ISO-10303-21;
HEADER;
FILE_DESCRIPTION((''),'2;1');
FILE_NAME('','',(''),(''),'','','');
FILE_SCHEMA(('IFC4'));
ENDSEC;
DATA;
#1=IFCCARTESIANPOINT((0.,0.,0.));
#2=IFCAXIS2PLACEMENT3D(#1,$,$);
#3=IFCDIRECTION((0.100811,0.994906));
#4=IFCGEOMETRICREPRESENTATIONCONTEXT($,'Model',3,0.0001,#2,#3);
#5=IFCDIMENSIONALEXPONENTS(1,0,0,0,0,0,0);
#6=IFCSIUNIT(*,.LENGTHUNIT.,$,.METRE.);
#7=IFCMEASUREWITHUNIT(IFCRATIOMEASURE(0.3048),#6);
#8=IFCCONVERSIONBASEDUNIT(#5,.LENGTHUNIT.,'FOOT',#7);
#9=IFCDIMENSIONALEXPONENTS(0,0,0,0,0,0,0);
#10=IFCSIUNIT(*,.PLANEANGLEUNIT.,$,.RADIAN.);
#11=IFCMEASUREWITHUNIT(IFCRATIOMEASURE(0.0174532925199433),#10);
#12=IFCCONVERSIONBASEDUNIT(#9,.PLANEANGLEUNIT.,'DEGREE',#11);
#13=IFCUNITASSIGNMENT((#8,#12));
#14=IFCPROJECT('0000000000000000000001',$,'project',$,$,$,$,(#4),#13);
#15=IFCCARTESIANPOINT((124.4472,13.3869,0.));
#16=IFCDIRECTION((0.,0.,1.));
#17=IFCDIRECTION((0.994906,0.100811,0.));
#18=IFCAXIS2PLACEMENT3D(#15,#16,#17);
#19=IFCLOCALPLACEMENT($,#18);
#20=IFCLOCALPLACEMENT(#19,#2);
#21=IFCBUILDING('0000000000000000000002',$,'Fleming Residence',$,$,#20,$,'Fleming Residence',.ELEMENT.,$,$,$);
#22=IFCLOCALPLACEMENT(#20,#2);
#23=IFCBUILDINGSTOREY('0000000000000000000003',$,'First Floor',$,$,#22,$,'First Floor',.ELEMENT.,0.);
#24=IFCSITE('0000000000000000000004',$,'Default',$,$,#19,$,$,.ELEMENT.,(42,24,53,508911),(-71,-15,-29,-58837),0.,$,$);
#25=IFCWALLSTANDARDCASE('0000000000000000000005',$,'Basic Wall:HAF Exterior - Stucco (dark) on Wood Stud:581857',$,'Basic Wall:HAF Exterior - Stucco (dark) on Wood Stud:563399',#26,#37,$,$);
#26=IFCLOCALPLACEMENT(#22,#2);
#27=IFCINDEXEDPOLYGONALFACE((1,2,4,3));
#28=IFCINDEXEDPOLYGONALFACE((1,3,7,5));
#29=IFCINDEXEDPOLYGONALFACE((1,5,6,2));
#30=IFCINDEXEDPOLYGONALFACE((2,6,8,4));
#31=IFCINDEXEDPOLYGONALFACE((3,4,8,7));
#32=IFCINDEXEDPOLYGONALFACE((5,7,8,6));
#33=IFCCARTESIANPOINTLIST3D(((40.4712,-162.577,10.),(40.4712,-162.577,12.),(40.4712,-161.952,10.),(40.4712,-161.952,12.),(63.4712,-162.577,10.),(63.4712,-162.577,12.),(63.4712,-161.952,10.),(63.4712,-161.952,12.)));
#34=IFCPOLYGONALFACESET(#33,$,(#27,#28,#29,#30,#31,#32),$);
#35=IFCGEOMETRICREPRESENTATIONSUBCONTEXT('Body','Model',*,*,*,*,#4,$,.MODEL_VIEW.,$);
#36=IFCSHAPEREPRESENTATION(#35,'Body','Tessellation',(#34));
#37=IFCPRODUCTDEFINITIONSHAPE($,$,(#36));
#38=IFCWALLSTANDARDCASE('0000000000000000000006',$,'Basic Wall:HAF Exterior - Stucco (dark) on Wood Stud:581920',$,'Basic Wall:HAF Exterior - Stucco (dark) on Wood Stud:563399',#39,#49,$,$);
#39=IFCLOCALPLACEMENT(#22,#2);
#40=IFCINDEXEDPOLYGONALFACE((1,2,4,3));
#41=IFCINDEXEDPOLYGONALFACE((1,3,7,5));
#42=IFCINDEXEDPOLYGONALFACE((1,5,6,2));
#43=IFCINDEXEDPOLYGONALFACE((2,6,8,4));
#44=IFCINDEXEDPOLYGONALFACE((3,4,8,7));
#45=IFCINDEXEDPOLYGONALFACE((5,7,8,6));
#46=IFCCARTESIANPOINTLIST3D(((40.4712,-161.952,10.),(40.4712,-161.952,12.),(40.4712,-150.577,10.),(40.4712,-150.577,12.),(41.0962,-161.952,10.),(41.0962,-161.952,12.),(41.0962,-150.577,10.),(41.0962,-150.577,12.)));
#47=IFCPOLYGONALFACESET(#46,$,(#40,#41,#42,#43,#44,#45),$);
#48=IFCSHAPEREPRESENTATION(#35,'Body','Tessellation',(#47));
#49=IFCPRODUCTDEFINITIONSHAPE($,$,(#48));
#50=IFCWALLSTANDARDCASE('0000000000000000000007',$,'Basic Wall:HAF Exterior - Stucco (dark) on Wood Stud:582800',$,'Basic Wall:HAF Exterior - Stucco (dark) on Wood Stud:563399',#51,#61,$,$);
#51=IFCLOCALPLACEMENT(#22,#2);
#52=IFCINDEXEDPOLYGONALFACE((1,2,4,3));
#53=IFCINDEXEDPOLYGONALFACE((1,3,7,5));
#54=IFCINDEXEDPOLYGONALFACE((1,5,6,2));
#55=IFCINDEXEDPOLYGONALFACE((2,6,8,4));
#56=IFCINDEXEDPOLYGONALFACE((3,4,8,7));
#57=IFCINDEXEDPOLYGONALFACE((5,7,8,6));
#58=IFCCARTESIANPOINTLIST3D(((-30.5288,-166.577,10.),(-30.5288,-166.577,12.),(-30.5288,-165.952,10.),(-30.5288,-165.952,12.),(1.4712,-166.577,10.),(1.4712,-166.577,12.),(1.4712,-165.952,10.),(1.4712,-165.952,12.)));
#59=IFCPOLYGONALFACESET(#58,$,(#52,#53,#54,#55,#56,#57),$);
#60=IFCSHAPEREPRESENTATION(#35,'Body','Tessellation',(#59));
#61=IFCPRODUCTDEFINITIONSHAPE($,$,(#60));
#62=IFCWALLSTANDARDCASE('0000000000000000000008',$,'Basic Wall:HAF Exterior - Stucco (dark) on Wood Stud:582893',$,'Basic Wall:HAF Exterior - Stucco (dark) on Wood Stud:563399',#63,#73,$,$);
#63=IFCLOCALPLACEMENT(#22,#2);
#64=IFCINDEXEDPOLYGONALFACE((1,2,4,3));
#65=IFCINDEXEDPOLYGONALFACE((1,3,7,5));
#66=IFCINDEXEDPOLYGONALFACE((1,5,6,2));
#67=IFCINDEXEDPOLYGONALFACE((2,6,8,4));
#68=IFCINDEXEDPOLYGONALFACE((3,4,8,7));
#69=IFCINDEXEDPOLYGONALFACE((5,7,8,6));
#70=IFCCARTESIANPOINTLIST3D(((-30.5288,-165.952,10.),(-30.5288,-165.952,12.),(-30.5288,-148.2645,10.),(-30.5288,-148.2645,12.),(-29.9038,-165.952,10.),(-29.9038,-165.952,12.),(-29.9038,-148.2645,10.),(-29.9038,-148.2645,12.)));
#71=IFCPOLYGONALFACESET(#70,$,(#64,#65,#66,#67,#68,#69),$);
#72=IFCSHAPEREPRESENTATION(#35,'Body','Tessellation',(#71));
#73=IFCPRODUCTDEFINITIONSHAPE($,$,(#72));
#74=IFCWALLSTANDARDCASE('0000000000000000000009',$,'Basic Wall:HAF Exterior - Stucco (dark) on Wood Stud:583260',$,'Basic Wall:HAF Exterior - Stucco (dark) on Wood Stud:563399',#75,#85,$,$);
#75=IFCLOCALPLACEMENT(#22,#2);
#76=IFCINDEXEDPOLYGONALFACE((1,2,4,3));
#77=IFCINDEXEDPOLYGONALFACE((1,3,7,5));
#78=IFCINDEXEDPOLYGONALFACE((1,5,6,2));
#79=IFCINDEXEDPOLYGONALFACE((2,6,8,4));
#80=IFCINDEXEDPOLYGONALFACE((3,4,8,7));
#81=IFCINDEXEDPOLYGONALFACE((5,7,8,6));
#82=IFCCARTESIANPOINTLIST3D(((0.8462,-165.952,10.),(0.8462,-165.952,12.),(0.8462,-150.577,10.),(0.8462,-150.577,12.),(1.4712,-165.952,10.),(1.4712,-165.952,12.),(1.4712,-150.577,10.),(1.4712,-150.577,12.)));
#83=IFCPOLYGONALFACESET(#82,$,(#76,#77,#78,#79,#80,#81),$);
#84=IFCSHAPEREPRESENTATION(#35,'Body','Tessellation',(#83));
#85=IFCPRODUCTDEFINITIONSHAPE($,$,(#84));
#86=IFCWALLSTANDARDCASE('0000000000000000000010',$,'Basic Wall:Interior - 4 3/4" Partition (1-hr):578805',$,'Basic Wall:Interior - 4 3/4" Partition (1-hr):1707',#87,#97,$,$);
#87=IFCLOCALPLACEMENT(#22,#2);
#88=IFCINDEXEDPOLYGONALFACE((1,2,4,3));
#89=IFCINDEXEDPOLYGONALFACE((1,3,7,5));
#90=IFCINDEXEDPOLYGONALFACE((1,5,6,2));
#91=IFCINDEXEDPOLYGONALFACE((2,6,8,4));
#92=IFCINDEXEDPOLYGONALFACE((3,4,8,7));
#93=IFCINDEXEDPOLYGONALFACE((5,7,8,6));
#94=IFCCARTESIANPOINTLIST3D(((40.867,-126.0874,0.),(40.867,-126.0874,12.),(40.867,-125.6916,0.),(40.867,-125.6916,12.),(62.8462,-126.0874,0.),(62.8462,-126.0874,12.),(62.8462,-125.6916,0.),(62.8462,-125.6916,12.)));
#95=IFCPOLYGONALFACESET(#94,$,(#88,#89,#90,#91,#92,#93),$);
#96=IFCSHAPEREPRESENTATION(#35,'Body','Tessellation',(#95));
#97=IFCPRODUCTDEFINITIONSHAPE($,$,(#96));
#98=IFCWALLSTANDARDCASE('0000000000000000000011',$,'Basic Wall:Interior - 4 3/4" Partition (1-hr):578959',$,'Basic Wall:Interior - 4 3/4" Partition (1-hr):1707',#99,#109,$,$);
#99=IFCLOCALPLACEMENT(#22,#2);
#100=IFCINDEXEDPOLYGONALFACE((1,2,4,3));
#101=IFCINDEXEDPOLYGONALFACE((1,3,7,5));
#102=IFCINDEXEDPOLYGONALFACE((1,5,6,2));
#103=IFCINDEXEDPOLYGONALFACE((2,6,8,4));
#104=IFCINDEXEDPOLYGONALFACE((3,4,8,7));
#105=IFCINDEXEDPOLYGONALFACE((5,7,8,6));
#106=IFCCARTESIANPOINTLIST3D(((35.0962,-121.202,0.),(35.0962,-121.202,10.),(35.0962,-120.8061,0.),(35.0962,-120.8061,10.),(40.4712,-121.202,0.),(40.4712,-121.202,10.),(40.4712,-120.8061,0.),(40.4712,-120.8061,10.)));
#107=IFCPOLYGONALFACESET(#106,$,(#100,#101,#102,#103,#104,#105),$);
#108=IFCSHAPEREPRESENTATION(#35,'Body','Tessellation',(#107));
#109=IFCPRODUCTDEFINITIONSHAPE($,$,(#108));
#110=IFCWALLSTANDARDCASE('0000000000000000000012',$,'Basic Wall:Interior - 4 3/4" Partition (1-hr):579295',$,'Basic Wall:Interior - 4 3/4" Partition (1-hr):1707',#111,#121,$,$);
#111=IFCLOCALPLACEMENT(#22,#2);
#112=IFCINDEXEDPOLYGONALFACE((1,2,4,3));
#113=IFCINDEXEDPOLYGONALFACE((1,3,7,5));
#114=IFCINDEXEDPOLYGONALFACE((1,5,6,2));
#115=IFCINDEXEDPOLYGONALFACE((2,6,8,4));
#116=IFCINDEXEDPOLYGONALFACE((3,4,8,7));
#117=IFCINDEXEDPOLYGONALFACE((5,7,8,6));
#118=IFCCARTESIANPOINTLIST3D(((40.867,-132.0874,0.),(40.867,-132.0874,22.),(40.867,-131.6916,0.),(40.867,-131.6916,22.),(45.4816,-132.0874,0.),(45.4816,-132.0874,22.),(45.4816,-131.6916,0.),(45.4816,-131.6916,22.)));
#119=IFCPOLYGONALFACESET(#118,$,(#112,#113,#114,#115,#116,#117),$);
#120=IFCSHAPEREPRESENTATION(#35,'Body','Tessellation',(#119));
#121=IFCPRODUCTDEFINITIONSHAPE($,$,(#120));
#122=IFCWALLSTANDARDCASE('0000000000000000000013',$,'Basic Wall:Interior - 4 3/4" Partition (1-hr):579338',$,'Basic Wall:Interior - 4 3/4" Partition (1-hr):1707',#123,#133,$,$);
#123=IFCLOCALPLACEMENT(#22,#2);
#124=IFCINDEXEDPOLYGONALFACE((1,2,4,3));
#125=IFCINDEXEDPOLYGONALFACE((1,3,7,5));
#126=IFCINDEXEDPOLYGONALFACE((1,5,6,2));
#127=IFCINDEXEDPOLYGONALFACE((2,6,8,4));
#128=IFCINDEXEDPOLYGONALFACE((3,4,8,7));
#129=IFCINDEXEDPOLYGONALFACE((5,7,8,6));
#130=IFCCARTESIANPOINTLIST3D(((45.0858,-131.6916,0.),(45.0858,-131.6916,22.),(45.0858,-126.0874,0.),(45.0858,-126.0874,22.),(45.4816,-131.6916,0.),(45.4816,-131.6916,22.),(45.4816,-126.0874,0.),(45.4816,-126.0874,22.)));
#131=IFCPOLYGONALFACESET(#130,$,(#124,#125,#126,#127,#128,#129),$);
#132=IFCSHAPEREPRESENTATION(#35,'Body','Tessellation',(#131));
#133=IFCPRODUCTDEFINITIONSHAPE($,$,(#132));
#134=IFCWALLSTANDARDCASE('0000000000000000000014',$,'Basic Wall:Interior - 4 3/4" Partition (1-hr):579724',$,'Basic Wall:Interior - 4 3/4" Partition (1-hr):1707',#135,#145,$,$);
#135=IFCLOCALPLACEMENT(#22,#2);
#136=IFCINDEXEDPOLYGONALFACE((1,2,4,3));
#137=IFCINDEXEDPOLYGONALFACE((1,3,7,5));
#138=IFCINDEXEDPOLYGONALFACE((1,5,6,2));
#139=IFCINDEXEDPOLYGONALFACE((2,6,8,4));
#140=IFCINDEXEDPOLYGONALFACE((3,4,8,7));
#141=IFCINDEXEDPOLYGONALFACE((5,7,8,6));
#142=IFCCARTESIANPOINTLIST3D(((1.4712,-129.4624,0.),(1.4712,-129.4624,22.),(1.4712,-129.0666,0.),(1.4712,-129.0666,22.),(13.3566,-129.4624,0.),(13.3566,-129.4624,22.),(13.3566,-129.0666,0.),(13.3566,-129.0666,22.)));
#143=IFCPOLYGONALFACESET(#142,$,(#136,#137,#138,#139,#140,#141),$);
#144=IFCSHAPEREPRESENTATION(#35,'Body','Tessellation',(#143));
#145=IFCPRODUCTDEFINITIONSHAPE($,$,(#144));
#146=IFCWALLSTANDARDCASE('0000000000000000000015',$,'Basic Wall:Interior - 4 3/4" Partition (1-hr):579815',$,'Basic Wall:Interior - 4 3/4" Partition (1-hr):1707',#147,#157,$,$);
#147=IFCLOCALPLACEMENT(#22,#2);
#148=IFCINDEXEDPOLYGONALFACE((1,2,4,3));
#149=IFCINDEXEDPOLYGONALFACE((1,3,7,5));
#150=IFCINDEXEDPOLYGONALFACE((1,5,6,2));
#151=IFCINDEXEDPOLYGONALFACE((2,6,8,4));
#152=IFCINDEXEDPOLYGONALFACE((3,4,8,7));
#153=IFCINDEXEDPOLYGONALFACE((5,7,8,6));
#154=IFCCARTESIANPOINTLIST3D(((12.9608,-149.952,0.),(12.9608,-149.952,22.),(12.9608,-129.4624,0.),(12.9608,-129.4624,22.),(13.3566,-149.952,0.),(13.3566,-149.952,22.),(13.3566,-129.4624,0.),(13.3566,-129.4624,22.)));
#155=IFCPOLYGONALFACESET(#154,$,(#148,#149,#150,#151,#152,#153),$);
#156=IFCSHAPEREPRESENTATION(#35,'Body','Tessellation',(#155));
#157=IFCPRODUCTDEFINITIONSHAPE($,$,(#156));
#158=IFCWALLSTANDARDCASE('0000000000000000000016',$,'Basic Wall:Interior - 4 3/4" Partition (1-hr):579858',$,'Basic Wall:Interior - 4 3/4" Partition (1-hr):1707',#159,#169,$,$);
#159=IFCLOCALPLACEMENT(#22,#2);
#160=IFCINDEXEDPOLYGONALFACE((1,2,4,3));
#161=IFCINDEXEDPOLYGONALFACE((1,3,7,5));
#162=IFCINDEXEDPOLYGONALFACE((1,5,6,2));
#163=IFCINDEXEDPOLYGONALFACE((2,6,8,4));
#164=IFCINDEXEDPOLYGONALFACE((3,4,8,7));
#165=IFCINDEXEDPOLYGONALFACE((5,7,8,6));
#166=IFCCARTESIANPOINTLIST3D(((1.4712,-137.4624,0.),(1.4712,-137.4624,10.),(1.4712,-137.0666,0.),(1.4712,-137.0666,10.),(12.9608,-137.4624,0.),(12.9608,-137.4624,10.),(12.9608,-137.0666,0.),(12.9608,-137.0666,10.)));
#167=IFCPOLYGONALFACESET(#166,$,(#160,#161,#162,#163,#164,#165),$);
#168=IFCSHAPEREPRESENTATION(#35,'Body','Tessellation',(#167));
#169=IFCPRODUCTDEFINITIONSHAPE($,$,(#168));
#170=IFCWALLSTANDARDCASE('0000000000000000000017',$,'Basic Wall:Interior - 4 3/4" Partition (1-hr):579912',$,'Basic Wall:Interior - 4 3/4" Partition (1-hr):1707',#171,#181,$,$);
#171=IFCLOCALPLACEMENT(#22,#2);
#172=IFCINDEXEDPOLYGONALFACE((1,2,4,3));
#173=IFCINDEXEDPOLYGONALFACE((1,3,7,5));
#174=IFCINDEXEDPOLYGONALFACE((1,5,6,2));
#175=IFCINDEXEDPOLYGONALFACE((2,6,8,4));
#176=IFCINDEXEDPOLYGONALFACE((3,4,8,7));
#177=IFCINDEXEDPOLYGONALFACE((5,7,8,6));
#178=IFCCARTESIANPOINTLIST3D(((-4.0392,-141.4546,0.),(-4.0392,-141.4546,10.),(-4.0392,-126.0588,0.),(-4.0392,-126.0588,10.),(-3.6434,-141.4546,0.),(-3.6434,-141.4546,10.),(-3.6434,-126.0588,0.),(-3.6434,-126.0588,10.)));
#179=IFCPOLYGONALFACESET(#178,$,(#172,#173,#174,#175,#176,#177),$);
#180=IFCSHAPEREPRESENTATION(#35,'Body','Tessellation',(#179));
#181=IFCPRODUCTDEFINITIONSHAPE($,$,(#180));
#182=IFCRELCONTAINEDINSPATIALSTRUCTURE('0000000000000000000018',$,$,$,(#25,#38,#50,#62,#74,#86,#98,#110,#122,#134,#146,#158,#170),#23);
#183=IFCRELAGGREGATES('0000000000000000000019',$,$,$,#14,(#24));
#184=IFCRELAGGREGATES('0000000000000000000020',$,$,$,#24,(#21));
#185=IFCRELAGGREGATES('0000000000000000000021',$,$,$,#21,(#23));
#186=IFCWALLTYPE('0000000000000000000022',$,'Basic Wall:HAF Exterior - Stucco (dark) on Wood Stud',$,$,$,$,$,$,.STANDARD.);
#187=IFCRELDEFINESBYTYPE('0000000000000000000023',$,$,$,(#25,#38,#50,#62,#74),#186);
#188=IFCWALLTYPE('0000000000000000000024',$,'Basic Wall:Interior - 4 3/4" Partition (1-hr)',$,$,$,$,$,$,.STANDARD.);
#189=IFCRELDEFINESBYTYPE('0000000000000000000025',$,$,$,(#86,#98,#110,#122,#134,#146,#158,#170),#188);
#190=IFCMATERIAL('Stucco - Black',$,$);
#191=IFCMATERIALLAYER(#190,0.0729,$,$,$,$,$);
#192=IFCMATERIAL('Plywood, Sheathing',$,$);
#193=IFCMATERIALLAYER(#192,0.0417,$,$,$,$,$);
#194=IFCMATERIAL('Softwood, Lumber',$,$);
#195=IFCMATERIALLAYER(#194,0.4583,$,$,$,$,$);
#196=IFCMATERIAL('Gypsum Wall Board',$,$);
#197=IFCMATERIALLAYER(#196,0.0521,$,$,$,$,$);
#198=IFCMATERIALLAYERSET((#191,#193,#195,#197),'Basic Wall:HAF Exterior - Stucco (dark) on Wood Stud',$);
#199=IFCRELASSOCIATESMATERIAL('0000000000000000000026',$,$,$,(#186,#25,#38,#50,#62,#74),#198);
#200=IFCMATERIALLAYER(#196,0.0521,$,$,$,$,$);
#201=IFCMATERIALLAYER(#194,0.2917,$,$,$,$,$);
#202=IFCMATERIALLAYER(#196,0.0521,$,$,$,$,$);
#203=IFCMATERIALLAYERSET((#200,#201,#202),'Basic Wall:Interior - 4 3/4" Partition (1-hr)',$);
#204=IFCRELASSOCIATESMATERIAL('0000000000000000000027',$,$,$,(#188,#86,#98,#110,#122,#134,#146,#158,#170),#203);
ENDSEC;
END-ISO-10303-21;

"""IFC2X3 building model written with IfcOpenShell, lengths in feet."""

from ifc_helpers import new_model, entity, si_unit, converted_unit, direction, frame, frame_2d, origin, place, context, subcontext, project, spatial, rectangle, extrude, material, layer, layer_set, layer_usage, type_object, element, save


model = new_model("IFC2X3")

# Units and contexts
model_context = context("Model", 3, precision=0.0001, world=origin(), true_north=direction((0.100811, 0.994906)))
body_context = subcontext(model_context, "Body", "Model", "MODEL_VIEW")
ifc_project = project(units=[converted_unit("LENGTHUNIT", "FOOT", entity("IfcRatioMeasure", 0.3048), si_unit("LENGTHUNIT", "METRE"), dimensions=[1, 0, 0, 0, 0, 0, 0]), converted_unit("PLANEANGLEUNIT", "DEGREE", entity("IfcRatioMeasure", 0.0174532925199433), si_unit("PLANEANGLEUNIT", "RADIAN"), dimensions=[0, 0, 0, 0, 0, 0, 0])], contexts=[model_context])

# Site, building, storey
site_placement = place(None, frame((124.4472, 13.3869, 0.0), z_axis=(0.0, 0.0, 1.0), x_axis=(0.994906, 0.100811, 0.0)))
site = spatial("IfcSite", under=ifc_project, at=site_placement, Name="Default", CompositionType="ELEMENT", RefLatitude=(42, 24, 53, 508911), RefLongitude=(-71, -15, -29, -58837), RefElevation=0.0)
building_placement = place(site_placement, origin())
building = spatial("IfcBuilding", under=site, at=building_placement, Name="Fleming Residence", LongName="Fleming Residence", CompositionType="ELEMENT")
storey_placement = place(building_placement, origin())
storey = spatial("IfcBuildingStorey", under=building, at=storey_placement, Name="First Floor", LongName="First Floor", CompositionType="ELEMENT", Elevation=0.0)

# Walls
ifc_material_1 = material(Name="Plywood, Sheathing")
ifc_material_2 = material(Name="Softwood, Lumber")
ifc_material_3 = material(Name="Gypsum Wall Board")
ifc_material_4 = material(Name="Stucco - Black")
ifc_layer_1 = layer(ifc_material_4, 0.0729)
ifc_layer_2 = layer(ifc_material_1, 0.0417)
ifc_layer_3 = layer(ifc_material_2, 0.4583)
ifc_layer_4 = layer(ifc_material_3, 0.0521)
ifc_layer_set_1 = layer_set([ifc_layer_1, ifc_layer_2, ifc_layer_3, ifc_layer_4], Name="Basic Wall:HAF Exterior - Stucco (dark) on Wood Stud")
wall_type_1 = type_object("IfcWallType", Name="Basic Wall:HAF Exterior - Stucco (dark) on Wood Stud", PredefinedType="STANDARD", material=ifc_layer_set_1)
ifc_layer_usage_1 = layer_usage(ifc_layer_set_1, "AXIS2", "NEGATIVE", 0.3125)
wall_1_placement = place(storey_placement, frame((63.4712, -162.2645, 10.0), z_axis=(0.0, 0.0, 1.0), x_axis=(-1.0, 0.0, 0.0)))
element("IfcWallStandardCase", 1, at=wall_1_placement, inside=storey, type_object=wall_type_1, material=ifc_layer_usage_1, Name="Basic Wall:HAF Exterior - Stucco (dark) on Wood Stud:581857", ObjectType="Basic Wall:HAF Exterior - Stucco (dark) on Wood Stud:563399", context=body_context, shape_type="SweptSolid", body=[
    extrude(rectangle(XDim=23.0, YDim=0.625, at=frame_2d((11.5, 0.0), x_axis=(-1.0, 0.0))), origin(), (0.0, 0.0, 1.0), 2.0),
])
ifc_layer_usage_2 = layer_usage(ifc_layer_set_1, "AXIS2", "NEGATIVE", 0.3125)
wall_2_placement = place(storey_placement, frame((40.7837, -161.952, 10.0), z_axis=(0.0, 0.0, 1.0), x_axis=(0.0, 1.0, 0.0)))
element("IfcWallStandardCase", 2, at=wall_2_placement, inside=storey, type_object=wall_type_1, material=ifc_layer_usage_2, Name="Basic Wall:HAF Exterior - Stucco (dark) on Wood Stud:581920", ObjectType="Basic Wall:HAF Exterior - Stucco (dark) on Wood Stud:563399", context=body_context, shape_type="SweptSolid", body=[
    extrude(rectangle(XDim=11.375, YDim=0.625, at=frame_2d((5.6875, 0.0), x_axis=(-1.0, 0.0))), origin(), (0.0, 0.0, 1.0), 2.0),
])
ifc_layer_usage_3 = layer_usage(ifc_layer_set_1, "AXIS2", "NEGATIVE", 0.3125)
wall_3_placement = place(storey_placement, frame((1.4712, -166.2645, 10.0), z_axis=(0.0, 0.0, 1.0), x_axis=(-1.0, 0.0, 0.0)))
element("IfcWallStandardCase", 3, at=wall_3_placement, inside=storey, type_object=wall_type_1, material=ifc_layer_usage_3, Name="Basic Wall:HAF Exterior - Stucco (dark) on Wood Stud:582800", ObjectType="Basic Wall:HAF Exterior - Stucco (dark) on Wood Stud:563399", context=body_context, shape_type="SweptSolid", body=[
    extrude(rectangle(XDim=32.0, YDim=0.625, at=frame_2d((16.0, 0.0), x_axis=(-1.0, 0.0))), origin(), (0.0, 0.0, 1.0), 2.0),
])
ifc_layer_usage_4 = layer_usage(ifc_layer_set_1, "AXIS2", "NEGATIVE", 0.3125)
wall_4_placement = place(storey_placement, frame((-30.2163, -165.952, 10.0), z_axis=(0.0, 0.0, 1.0), x_axis=(0.0, 1.0, 0.0)))
element("IfcWallStandardCase", 4, at=wall_4_placement, inside=storey, type_object=wall_type_1, material=ifc_layer_usage_4, Name="Basic Wall:HAF Exterior - Stucco (dark) on Wood Stud:582893", ObjectType="Basic Wall:HAF Exterior - Stucco (dark) on Wood Stud:563399", context=body_context, shape_type="SweptSolid", body=[
    extrude(rectangle(XDim=17.6875, YDim=0.625, at=frame_2d((8.8438, 0.0), x_axis=(-1.0, 0.0))), origin(), (0.0, 0.0, 1.0), 2.0),
])
ifc_layer_usage_5 = layer_usage(ifc_layer_set_1, "AXIS2", "NEGATIVE", 0.3125)
wall_5_placement = place(storey_placement, frame((1.1587, -150.577, 10.0), z_axis=(0.0, 0.0, 1.0), x_axis=(0.0, -1.0, 0.0)))
element("IfcWallStandardCase", 5, at=wall_5_placement, inside=storey, type_object=wall_type_1, material=ifc_layer_usage_5, Name="Basic Wall:HAF Exterior - Stucco (dark) on Wood Stud:583260", ObjectType="Basic Wall:HAF Exterior - Stucco (dark) on Wood Stud:563399", context=body_context, shape_type="SweptSolid", body=[
    extrude(rectangle(XDim=15.375, YDim=0.625, at=frame_2d((7.6875, 0.0), x_axis=(-1.0, 0.0))), origin(), (0.0, 0.0, 1.0), 2.0),
])
ifc_layer_5 = layer(ifc_material_3, 0.0521)
ifc_layer_6 = layer(ifc_material_2, 0.2917)
ifc_layer_7 = layer(ifc_material_3, 0.0521)
ifc_layer_set_2 = layer_set([ifc_layer_5, ifc_layer_6, ifc_layer_7], Name="Basic Wall:Interior - 4 3/4\" Partition (1-hr)")
ifc_layer_usage_6 = layer_usage(ifc_layer_set_2, "AXIS2", "NEGATIVE", 0.1979)
wall_type_2 = type_object("IfcWallType", Name="Basic Wall:Interior - 4 3/4\" Partition (1-hr)", PredefinedType="STANDARD", material=ifc_layer_set_2)
wall_6_placement = place(storey_placement, frame((40.867, -125.8895, 0.0)))
element("IfcWallStandardCase", 6, at=wall_6_placement, inside=storey, type_object=wall_type_2, material=ifc_layer_usage_6, Name="Basic Wall:Interior - 4 3/4\" Partition (1-hr):578805", ObjectType="Basic Wall:Interior - 4 3/4\" Partition (1-hr):1707", context=body_context, shape_type="SweptSolid", body=[
    extrude(rectangle(XDim=21.9792, YDim=0.3958, at=frame_2d((10.9896, 0.0), x_axis=(-1.0, 0.0))), origin(), (0.0, 0.0, 1.0), 12.0),
])
ifc_layer_usage_7 = layer_usage(ifc_layer_set_2, "AXIS2", "NEGATIVE", 0.1979)
wall_7_placement = place(storey_placement, frame((35.0962, -121.0041, 0.0)))
element("IfcWallStandardCase", 7, at=wall_7_placement, inside=storey, type_object=wall_type_2, material=ifc_layer_usage_7, Name="Basic Wall:Interior - 4 3/4\" Partition (1-hr):578959", ObjectType="Basic Wall:Interior - 4 3/4\" Partition (1-hr):1707", context=body_context, shape_type="SweptSolid", body=[
    extrude(rectangle(XDim=5.375, YDim=0.3958, at=frame_2d((2.6875, 0.0), x_axis=(-1.0, 0.0))), origin(), (0.0, 0.0, 1.0), 10.0),
])
ifc_layer_usage_8 = layer_usage(ifc_layer_set_2, "AXIS2", "NEGATIVE", 0.1979)
wall_8_placement = place(storey_placement, frame((40.867, -131.8895, 0.0)))
element("IfcWallStandardCase", 8, at=wall_8_placement, inside=storey, type_object=wall_type_2, material=ifc_layer_usage_8, Name="Basic Wall:Interior - 4 3/4\" Partition (1-hr):579295", ObjectType="Basic Wall:Interior - 4 3/4\" Partition (1-hr):1707", context=body_context, shape_type="SweptSolid", body=[
    extrude(rectangle(XDim=4.6146, YDim=0.3958, at=frame_2d((2.3073, 0.0), x_axis=(-1.0, 0.0))), origin(), (0.0, 0.0, 1.0), 22.0),
])
ifc_layer_usage_9 = layer_usage(ifc_layer_set_2, "AXIS2", "NEGATIVE", 0.1979)
wall_9_placement = place(storey_placement, frame((45.2837, -131.6916, 0.0), z_axis=(0.0, 0.0, 1.0), x_axis=(0.0, 1.0, 0.0)))
element("IfcWallStandardCase", 9, at=wall_9_placement, inside=storey, type_object=wall_type_2, material=ifc_layer_usage_9, Name="Basic Wall:Interior - 4 3/4\" Partition (1-hr):579338", ObjectType="Basic Wall:Interior - 4 3/4\" Partition (1-hr):1707", context=body_context, shape_type="SweptSolid", body=[
    extrude(rectangle(XDim=5.6042, YDim=0.3958, at=frame_2d((2.8021, 0.0), x_axis=(-1.0, 0.0))), origin(), (0.0, 0.0, 1.0), 22.0),
])
ifc_layer_usage_10 = layer_usage(ifc_layer_set_2, "AXIS2", "NEGATIVE", 0.1979)
wall_10_placement = place(storey_placement, frame((1.4712, -129.2645, 0.0)))
element("IfcWallStandardCase", 10, at=wall_10_placement, inside=storey, type_object=wall_type_2, material=ifc_layer_usage_10, Name="Basic Wall:Interior - 4 3/4\" Partition (1-hr):579724", ObjectType="Basic Wall:Interior - 4 3/4\" Partition (1-hr):1707", context=body_context, shape_type="SweptSolid", body=[
    extrude(rectangle(XDim=11.8854, YDim=0.3958, at=frame_2d((5.9427, 0.0), x_axis=(-1.0, 0.0))), origin(), (0.0, 0.0, 1.0), 22.0),
])
ifc_layer_usage_11 = layer_usage(ifc_layer_set_2, "AXIS2", "NEGATIVE", 0.1979)
wall_11_placement = place(storey_placement, frame((13.1587, -129.4624, 0.0), z_axis=(0.0, 0.0, 1.0), x_axis=(0.0, -1.0, 0.0)))
element("IfcWallStandardCase", 11, at=wall_11_placement, inside=storey, type_object=wall_type_2, material=ifc_layer_usage_11, Name="Basic Wall:Interior - 4 3/4\" Partition (1-hr):579815", ObjectType="Basic Wall:Interior - 4 3/4\" Partition (1-hr):1707", context=body_context, shape_type="SweptSolid", body=[
    extrude(rectangle(XDim=20.4896, YDim=0.3958, at=frame_2d((10.2448, 0.0), x_axis=(-1.0, 0.0))), origin(), (0.0, 0.0, 1.0), 22.0),
])
ifc_layer_usage_12 = layer_usage(ifc_layer_set_2, "AXIS2", "NEGATIVE", 0.1979)
wall_12_placement = place(storey_placement, frame((1.4712, -137.2645, 0.0)))
element("IfcWallStandardCase", 12, at=wall_12_placement, inside=storey, type_object=wall_type_2, material=ifc_layer_usage_12, Name="Basic Wall:Interior - 4 3/4\" Partition (1-hr):579858", ObjectType="Basic Wall:Interior - 4 3/4\" Partition (1-hr):1707", context=body_context, shape_type="SweptSolid", body=[
    extrude(rectangle(XDim=11.4896, YDim=0.3958, at=frame_2d((5.7448, 0.0), x_axis=(-1.0, 0.0))), origin(), (0.0, 0.0, 1.0), 10.0),
])
ifc_layer_usage_13 = layer_usage(ifc_layer_set_2, "AXIS2", "NEGATIVE", 0.1979)
wall_13_placement = place(storey_placement, frame((-3.8413, -126.0588, 0.0), z_axis=(0.0, 0.0, 1.0), x_axis=(0.0, -1.0, 0.0)))
element("IfcWallStandardCase", 13, at=wall_13_placement, inside=storey, type_object=wall_type_2, material=ifc_layer_usage_13, Name="Basic Wall:Interior - 4 3/4\" Partition (1-hr):579912", ObjectType="Basic Wall:Interior - 4 3/4\" Partition (1-hr):1707", context=body_context, shape_type="SweptSolid", body=[
    extrude(rectangle(XDim=15.3958, YDim=0.3958, at=frame_2d((7.6979, 0.0), x_axis=(-1.0, 0.0))), origin(), (0.0, 0.0, 1.0), 10.0),
])

save(model, "model.ifc")
